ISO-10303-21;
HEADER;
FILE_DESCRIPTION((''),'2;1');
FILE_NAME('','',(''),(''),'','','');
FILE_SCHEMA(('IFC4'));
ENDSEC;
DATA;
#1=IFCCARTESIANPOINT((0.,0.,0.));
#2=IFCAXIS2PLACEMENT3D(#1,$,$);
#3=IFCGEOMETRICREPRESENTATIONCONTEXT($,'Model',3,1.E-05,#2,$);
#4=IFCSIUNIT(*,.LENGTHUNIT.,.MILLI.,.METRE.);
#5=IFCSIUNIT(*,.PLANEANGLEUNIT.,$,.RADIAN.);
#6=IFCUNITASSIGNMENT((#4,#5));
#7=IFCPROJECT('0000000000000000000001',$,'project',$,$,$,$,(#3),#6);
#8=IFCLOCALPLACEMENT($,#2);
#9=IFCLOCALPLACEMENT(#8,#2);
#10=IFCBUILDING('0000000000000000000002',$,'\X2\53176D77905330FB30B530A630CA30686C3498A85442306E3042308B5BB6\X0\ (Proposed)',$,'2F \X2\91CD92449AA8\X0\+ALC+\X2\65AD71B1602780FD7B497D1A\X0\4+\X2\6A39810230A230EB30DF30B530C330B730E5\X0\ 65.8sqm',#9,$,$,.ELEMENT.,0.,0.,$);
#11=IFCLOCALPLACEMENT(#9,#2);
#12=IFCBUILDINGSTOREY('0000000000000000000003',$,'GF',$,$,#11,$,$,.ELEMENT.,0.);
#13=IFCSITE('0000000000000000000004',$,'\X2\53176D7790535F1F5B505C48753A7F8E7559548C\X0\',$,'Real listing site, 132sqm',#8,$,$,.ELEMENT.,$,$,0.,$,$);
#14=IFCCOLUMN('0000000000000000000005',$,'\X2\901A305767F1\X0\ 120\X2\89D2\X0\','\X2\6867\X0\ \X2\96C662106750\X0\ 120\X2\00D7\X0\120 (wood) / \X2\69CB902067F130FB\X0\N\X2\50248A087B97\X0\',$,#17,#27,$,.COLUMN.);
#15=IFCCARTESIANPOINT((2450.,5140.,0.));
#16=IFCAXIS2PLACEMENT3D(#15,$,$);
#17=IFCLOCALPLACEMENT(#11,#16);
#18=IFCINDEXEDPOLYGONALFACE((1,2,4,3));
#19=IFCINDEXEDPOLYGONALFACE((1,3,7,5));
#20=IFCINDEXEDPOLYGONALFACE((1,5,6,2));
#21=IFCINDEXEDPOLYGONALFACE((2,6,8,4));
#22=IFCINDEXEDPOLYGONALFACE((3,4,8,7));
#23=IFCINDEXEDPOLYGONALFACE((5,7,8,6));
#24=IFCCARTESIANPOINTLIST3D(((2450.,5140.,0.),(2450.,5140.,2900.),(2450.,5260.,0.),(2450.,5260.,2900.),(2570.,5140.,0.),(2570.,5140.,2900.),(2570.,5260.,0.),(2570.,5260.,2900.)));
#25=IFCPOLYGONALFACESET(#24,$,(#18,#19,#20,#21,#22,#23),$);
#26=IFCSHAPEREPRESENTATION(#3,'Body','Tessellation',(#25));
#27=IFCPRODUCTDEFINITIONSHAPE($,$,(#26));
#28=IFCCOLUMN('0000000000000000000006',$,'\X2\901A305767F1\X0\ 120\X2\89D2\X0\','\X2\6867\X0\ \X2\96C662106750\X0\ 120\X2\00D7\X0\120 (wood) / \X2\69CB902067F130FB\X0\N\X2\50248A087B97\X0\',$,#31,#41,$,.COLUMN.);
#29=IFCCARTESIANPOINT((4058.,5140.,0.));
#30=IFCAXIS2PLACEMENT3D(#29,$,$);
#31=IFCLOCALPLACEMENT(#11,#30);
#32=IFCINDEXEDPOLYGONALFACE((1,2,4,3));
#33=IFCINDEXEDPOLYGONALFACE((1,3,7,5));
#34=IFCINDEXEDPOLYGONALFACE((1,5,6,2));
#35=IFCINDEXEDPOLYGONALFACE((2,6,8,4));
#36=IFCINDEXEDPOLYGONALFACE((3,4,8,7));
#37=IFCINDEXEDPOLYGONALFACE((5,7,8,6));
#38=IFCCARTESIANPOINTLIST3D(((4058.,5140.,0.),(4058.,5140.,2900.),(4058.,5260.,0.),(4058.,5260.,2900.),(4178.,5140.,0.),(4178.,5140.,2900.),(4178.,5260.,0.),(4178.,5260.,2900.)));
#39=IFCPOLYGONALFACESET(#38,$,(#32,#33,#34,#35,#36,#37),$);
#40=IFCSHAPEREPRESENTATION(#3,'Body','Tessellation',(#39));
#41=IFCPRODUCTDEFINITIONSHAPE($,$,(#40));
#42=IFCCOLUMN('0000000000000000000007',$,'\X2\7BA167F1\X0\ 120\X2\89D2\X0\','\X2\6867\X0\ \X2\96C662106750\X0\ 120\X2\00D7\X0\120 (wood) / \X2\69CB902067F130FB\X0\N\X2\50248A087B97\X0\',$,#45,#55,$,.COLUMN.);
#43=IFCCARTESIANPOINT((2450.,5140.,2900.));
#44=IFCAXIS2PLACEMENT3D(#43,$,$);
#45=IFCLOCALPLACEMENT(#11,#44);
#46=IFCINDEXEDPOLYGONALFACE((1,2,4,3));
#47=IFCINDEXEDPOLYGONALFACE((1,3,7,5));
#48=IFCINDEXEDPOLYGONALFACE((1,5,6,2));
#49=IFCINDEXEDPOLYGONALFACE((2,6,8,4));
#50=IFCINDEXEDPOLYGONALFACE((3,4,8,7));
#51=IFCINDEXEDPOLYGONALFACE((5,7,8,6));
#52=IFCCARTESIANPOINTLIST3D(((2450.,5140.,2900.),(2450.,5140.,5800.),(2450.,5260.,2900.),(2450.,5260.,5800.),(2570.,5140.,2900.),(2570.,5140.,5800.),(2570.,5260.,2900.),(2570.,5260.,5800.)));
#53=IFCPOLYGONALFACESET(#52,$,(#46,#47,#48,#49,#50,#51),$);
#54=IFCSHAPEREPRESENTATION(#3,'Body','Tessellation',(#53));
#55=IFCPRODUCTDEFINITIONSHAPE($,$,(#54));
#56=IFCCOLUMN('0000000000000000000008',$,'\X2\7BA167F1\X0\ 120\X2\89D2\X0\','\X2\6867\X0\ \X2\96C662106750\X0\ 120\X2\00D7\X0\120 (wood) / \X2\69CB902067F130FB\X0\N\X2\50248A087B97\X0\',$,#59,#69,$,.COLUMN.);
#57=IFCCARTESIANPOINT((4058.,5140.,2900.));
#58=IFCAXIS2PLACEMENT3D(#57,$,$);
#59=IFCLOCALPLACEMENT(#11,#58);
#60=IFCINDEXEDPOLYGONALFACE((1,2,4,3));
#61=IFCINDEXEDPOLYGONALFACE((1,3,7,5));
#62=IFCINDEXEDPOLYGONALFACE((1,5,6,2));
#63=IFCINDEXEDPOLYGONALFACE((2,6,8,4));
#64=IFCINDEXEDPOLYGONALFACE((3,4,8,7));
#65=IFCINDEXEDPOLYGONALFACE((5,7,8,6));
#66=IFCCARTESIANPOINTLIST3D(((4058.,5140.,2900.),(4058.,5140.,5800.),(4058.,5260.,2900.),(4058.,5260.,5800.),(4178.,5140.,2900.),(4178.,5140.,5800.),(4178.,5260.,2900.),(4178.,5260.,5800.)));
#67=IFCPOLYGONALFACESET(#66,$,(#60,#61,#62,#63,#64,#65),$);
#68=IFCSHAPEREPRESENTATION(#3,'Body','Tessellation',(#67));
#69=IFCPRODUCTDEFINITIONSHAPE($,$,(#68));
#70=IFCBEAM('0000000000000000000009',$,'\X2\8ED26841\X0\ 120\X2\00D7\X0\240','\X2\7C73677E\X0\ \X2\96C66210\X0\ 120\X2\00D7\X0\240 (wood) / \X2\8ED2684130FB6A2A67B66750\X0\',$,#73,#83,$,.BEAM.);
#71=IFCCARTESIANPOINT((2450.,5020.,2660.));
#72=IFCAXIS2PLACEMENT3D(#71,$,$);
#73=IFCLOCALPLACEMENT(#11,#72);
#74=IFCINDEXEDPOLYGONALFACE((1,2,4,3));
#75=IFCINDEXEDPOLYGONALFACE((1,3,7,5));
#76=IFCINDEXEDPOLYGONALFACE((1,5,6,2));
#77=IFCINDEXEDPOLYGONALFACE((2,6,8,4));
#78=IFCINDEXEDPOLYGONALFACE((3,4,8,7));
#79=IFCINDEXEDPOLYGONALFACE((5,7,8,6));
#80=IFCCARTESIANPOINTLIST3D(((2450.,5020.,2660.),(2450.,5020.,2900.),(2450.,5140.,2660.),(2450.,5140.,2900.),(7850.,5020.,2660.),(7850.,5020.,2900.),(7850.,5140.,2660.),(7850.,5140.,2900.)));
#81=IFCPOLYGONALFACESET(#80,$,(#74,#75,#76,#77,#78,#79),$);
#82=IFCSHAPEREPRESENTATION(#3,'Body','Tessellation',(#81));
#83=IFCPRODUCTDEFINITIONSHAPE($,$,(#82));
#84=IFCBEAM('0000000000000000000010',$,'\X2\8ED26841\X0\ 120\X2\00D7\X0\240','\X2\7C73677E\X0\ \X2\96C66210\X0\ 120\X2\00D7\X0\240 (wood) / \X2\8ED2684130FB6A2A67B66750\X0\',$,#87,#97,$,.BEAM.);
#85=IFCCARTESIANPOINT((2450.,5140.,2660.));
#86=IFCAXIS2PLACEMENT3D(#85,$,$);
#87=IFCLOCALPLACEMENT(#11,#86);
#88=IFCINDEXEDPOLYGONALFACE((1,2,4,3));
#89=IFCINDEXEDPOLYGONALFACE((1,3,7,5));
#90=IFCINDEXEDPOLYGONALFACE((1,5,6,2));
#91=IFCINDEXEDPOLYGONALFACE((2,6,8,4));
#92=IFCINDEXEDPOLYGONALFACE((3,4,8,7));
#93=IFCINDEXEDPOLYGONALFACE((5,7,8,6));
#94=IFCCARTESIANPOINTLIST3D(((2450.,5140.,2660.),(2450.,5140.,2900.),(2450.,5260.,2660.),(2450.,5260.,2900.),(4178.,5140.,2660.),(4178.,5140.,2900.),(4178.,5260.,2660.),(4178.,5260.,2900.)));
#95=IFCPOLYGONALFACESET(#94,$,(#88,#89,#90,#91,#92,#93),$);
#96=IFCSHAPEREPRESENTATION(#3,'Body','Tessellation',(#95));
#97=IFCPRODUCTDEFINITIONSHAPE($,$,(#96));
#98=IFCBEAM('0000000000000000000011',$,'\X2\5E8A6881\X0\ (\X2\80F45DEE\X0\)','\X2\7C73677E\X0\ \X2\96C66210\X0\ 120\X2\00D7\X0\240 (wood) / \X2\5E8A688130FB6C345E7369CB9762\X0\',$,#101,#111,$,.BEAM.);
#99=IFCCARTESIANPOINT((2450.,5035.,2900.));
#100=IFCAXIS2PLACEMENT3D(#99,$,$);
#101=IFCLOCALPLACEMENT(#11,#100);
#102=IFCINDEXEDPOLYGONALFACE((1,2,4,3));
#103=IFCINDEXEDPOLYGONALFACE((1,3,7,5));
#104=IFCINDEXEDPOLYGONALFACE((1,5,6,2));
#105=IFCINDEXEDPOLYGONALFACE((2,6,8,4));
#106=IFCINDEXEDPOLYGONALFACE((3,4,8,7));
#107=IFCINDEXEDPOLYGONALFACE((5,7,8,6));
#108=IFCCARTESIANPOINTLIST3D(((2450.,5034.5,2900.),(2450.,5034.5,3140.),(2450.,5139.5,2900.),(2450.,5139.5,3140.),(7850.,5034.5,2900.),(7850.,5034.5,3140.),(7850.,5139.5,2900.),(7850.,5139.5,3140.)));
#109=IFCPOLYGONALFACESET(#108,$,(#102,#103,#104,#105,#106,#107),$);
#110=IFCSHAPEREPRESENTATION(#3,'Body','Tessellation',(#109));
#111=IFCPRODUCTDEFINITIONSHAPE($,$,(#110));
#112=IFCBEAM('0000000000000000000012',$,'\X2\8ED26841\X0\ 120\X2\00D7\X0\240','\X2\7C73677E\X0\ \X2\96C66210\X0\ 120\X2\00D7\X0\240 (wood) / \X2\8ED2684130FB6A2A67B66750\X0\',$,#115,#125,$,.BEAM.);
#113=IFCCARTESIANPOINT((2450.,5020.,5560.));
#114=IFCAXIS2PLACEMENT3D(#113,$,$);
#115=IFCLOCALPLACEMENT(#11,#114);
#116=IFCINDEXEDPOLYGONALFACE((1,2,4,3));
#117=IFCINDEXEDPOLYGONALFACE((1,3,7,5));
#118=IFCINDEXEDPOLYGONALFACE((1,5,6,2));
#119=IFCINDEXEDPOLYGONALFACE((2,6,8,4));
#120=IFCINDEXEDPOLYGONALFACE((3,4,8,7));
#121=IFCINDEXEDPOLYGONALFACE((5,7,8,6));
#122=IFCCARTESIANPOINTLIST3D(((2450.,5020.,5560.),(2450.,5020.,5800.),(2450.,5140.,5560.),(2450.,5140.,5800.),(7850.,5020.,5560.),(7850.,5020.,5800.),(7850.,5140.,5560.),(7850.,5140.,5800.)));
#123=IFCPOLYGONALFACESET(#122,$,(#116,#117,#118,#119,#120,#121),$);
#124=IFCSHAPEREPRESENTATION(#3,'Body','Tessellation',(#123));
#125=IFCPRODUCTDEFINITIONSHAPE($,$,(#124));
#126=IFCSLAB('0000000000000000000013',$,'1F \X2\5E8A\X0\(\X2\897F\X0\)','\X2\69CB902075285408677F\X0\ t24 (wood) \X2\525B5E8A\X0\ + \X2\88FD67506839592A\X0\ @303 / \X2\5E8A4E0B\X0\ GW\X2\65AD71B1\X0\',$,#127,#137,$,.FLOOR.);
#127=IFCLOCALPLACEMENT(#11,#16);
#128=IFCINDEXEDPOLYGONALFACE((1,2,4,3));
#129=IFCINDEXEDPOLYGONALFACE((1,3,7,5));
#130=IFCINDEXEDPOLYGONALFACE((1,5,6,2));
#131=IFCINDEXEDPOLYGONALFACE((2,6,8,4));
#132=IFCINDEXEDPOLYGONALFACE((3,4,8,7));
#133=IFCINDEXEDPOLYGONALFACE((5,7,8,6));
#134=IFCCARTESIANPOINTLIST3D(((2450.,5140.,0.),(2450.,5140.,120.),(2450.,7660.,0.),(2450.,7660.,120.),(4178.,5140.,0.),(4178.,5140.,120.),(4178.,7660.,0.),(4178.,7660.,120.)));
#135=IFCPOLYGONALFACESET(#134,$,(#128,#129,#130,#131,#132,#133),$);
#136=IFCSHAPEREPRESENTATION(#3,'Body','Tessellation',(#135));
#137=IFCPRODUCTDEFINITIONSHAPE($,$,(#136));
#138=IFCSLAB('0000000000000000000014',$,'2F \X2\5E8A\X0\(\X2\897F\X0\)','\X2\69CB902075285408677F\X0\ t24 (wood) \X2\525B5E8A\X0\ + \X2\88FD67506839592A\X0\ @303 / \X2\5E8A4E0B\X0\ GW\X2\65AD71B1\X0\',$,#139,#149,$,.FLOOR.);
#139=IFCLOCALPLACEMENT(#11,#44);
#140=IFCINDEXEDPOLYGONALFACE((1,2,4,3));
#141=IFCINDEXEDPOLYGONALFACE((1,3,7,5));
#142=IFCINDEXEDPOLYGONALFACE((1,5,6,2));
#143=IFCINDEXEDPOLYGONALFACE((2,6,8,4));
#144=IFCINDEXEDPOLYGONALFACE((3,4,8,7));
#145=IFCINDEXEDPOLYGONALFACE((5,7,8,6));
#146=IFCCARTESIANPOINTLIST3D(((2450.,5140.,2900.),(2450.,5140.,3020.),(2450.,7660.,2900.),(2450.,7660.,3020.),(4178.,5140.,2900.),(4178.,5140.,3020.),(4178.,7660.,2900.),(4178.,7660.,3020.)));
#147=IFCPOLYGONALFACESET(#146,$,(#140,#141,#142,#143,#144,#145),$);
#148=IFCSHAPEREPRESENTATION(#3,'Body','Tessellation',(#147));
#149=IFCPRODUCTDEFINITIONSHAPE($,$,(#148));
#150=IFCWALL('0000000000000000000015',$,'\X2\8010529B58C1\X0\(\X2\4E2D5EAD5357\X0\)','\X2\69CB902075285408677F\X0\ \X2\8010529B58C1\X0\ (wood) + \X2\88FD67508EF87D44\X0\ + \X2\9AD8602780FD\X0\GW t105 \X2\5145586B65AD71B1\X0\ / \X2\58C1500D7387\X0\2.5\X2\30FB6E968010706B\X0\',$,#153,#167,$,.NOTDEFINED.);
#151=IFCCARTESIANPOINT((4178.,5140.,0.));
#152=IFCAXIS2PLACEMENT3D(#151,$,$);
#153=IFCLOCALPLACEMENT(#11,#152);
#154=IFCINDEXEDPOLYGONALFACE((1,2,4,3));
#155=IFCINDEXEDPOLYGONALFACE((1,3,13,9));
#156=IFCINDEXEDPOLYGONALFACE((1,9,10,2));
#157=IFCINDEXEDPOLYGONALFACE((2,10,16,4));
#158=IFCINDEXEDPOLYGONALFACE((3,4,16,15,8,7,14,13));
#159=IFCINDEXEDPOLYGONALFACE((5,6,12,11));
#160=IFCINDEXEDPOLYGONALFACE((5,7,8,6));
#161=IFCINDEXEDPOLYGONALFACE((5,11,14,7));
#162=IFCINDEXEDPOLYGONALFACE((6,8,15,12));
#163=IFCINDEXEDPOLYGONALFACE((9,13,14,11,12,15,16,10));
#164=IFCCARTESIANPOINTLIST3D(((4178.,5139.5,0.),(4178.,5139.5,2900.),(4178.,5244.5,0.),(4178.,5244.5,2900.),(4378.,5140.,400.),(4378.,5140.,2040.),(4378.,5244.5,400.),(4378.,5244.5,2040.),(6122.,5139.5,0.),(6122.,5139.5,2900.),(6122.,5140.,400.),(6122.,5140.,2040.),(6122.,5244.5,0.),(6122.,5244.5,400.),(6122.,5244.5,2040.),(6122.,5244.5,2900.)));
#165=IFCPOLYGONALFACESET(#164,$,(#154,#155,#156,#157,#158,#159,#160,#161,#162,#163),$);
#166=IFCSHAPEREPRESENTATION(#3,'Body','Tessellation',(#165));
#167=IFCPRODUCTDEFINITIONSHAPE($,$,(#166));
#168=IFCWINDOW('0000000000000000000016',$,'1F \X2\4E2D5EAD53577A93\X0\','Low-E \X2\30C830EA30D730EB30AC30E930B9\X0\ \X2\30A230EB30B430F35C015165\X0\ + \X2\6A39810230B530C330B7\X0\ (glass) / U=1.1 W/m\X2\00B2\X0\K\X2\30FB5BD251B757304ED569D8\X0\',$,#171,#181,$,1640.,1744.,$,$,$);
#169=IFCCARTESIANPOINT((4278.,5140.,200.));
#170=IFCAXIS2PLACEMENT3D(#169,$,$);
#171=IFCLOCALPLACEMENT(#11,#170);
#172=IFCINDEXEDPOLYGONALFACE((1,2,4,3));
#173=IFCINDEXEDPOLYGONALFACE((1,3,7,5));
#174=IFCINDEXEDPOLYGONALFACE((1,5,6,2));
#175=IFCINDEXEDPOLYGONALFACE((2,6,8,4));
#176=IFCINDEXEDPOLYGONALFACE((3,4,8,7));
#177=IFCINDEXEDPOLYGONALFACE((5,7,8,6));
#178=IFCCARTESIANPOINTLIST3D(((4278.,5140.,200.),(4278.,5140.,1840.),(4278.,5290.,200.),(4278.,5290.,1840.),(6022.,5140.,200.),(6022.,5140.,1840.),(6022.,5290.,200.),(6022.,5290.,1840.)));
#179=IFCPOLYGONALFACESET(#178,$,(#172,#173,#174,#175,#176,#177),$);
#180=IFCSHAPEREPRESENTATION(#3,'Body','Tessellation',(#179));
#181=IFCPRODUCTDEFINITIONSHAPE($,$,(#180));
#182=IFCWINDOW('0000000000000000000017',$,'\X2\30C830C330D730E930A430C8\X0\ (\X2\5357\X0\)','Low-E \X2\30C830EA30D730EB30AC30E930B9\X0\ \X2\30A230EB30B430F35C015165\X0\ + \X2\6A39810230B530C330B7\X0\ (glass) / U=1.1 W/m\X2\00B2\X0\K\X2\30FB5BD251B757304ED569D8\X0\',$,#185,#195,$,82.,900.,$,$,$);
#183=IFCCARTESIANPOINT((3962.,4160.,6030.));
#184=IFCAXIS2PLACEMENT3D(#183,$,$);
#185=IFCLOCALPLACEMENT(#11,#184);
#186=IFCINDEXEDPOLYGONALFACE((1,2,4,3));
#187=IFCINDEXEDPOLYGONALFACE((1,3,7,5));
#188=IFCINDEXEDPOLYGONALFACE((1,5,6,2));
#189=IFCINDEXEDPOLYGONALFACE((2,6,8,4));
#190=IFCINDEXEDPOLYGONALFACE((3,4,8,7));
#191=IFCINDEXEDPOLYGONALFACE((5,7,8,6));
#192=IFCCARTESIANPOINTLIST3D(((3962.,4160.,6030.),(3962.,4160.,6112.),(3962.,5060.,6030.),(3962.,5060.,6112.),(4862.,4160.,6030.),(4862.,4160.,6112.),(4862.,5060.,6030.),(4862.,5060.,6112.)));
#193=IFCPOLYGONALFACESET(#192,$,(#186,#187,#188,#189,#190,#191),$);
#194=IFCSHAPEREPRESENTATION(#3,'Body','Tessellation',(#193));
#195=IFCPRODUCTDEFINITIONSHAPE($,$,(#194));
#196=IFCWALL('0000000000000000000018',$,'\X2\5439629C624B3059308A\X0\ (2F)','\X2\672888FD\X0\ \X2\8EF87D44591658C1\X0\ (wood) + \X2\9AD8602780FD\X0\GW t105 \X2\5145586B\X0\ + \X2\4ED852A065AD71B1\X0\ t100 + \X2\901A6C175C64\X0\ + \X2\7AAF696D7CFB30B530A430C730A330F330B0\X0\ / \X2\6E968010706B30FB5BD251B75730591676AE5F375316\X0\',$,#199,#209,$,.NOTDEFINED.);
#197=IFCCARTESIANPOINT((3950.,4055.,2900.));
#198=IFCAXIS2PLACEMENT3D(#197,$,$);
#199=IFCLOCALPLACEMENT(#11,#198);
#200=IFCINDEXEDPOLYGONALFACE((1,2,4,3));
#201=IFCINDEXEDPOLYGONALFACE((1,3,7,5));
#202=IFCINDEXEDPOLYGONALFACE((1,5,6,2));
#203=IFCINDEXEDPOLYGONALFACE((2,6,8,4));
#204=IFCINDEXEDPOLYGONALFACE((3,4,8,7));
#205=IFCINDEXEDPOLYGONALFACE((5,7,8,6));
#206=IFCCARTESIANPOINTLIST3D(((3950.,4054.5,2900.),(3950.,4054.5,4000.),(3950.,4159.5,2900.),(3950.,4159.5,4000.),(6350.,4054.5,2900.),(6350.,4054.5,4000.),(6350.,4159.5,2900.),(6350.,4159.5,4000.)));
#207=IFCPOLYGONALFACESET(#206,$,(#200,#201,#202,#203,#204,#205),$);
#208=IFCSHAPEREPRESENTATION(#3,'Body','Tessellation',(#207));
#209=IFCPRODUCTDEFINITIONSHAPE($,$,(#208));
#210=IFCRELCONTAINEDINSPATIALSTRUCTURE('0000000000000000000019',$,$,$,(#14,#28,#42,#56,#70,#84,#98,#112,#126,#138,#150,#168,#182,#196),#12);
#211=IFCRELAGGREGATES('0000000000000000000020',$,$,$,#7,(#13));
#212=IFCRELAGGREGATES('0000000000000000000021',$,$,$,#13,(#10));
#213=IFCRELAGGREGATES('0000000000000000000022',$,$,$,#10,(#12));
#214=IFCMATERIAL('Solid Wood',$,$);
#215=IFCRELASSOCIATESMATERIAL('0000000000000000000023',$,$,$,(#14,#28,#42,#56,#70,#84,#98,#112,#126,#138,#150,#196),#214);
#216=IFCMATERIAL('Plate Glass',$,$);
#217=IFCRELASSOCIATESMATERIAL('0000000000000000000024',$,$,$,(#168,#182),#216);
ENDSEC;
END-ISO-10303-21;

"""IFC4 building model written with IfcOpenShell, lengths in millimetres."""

from ifc_helpers import new_model, si_unit, frame, frame_2d, origin, place, context, project, spatial, rectangle, extrude, material, element, fill, save


model = new_model("IFC4")

# Units and contexts
model_context = context("Model", 3, precision=1e-05, world=origin())
ifc_project = project(units=[si_unit("LENGTHUNIT", "METRE", prefix="MILLI"), si_unit("PLANEANGLEUNIT", "RADIAN")], contexts=[model_context])

# Site, building, storey
site_placement = place(None, origin())
site = spatial("IfcSite", under=ifc_project, at=site_placement, Name="北海道弟子屈町美留和", ObjectType="Real listing site, 132sqm", CompositionType="ELEMENT", RefElevation=0.0)
building_placement = place(site_placement, origin())
building = spatial("IfcBuilding", under=site, at=building_placement, Name="北海道・サウナと水風呂のある家 (Proposed)", ObjectType="2F 重鉄骨+ALC+断熱性能等級4+樹脂アルミサッシュ 65.8sqm", CompositionType="ELEMENT", ElevationOfRefHeight=0.0, ElevationOfTerrain=0.0)
storey_placement = place(building_placement, origin())
storey = spatial("IfcBuildingStorey", under=building, at=storey_placement, Name="GF", CompositionType="ELEMENT", Elevation=0.0)

# Columns
ifc_material_1 = material(Name="Solid Wood")
column_1_placement = place(storey_placement, frame((2450.0, 5140.0, 0.0)))
element("IfcColumn", 1, at=column_1_placement, inside=storey, material=ifc_material_1, Name="通し柱 120角", Description="桧 集成材 120×120 (wood) / 構造柱・N値計算", PredefinedType="COLUMN", context=model_context, shape_type="SweptSolid", body=[
    extrude(rectangle(XDim=120.0, YDim=120.0, at=frame_2d((60.0, 60.0))), frame((2450.0, 5140.0, 0.0)), (0.0, 0.0, 1.0), 2900.0),
])
column_2_placement = place(storey_placement, frame((4058.0, 5140.0, 0.0)))
element("IfcColumn", 2, at=column_2_placement, inside=storey, material=ifc_material_1, Name="通し柱 120角", Description="桧 集成材 120×120 (wood) / 構造柱・N値計算", PredefinedType="COLUMN", context=model_context, shape_type="SweptSolid", body=[
    extrude(rectangle(XDim=120.0, YDim=120.0, at=frame_2d((60.0, 60.0))), frame((4058.0, 5140.0, 0.0)), (0.0, 0.0, 1.0), 2900.0),
])
column_3_placement = place(storey_placement, frame((2450.0, 5140.0, 2900.0)))
element("IfcColumn", 3, at=column_3_placement, inside=storey, material=ifc_material_1, Name="管柱 120角", Description="桧 集成材 120×120 (wood) / 構造柱・N値計算", PredefinedType="COLUMN", context=model_context, shape_type="SweptSolid", body=[
    extrude(rectangle(XDim=120.0, YDim=120.0, at=frame_2d((60.0, 60.0))), frame((2450.0, 5140.0, 2900.0)), (0.0, 0.0, 1.0), 2900.0),
])
column_4_placement = place(storey_placement, frame((4058.0, 5140.0, 2900.0)))
element("IfcColumn", 4, at=column_4_placement, inside=storey, material=ifc_material_1, Name="管柱 120角", Description="桧 集成材 120×120 (wood) / 構造柱・N値計算", PredefinedType="COLUMN", context=model_context, shape_type="SweptSolid", body=[
    extrude(rectangle(XDim=120.0, YDim=120.0, at=frame_2d((60.0, 60.0))), frame((4058.0, 5140.0, 2900.0)), (0.0, 0.0, 1.0), 2900.0),
])

# Beams
beam_1_placement = place(storey_placement, frame((2450.0, 5020.0, 2660.0)))
element("IfcBeam", 5, at=beam_1_placement, inside=storey, material=ifc_material_1, Name="軒桁 120×240", Description="米松 集成 120×240 (wood) / 軒桁・横架材", PredefinedType="BEAM", context=model_context, shape_type="SweptSolid", body=[
    extrude(rectangle(XDim=5400.0, YDim=120.0, at=frame_2d((2700.0, 60.0))), frame((2450.0, 5020.0, 2660.0)), (0.0, 0.0, 1.0), 240.0),
])
beam_2_placement = place(storey_placement, frame((2450.0, 5140.0, 2660.0)))
element("IfcBeam", 6, at=beam_2_placement, inside=storey, material=ifc_material_1, Name="軒桁 120×240", Description="米松 集成 120×240 (wood) / 軒桁・横架材", PredefinedType="BEAM", context=model_context, shape_type="SweptSolid", body=[
    extrude(rectangle(XDim=1728.0, YDim=120.0, at=frame_2d((864.0, 60.0))), frame((2450.0, 5140.0, 2660.0)), (0.0, 0.0, 1.0), 240.0),
])
beam_3_placement = place(storey_placement, frame((2450.0, 5035.0, 2900.0)))
element("IfcBeam", 7, at=beam_3_placement, inside=storey, material=ifc_material_1, Name="床梁 (胴差)", Description="米松 集成 120×240 (wood) / 床梁・水平構面", PredefinedType="BEAM", context=model_context, shape_type="SweptSolid", body=[
    extrude(rectangle(XDim=5400.0, YDim=105.0, at=frame_2d((2700.0, 52.0))), frame((2450.0, 5035.0, 2900.0)), (0.0, 0.0, 1.0), 240.0),
])
beam_4_placement = place(storey_placement, frame((2450.0, 5020.0, 5560.0)))
element("IfcBeam", 8, at=beam_4_placement, inside=storey, material=ifc_material_1, Name="軒桁 120×240", Description="米松 集成 120×240 (wood) / 軒桁・横架材", PredefinedType="BEAM", context=model_context, shape_type="SweptSolid", body=[
    extrude(rectangle(XDim=5400.0, YDim=120.0, at=frame_2d((2700.0, 60.0))), frame((2450.0, 5020.0, 5560.0)), (0.0, 0.0, 1.0), 240.0),
])

# Slabs
slab_1_placement = place(storey_placement, frame((2450.0, 5140.0, 0.0)))
element("IfcSlab", 9, at=slab_1_placement, inside=storey, material=ifc_material_1, Name="1F 床(西)", Description="構造用合板 t24 (wood) 剛床 + 製材根太 @303 / 床下 GW断熱", PredefinedType="FLOOR", context=model_context, shape_type="SweptSolid", body=[
    extrude(rectangle(XDim=1728.0, YDim=2520.0, at=frame_2d((864.0, 1260.0))), frame((2450.0, 5140.0, 0.0)), (0.0, 0.0, 1.0), 120.0),
])
slab_2_placement = place(storey_placement, frame((2450.0, 5140.0, 2900.0)))
element("IfcSlab", 10, at=slab_2_placement, inside=storey, material=ifc_material_1, Name="2F 床(西)", Description="構造用合板 t24 (wood) 剛床 + 製材根太 @303 / 床下 GW断熱", PredefinedType="FLOOR", context=model_context, shape_type="SweptSolid", body=[
    extrude(rectangle(XDim=1728.0, YDim=2520.0, at=frame_2d((864.0, 1260.0))), frame((2450.0, 5140.0, 2900.0)), (0.0, 0.0, 1.0), 120.0),
])

# Wall, opening, window
wall_1_placement = place(storey_placement, frame((4178.0, 5140.0, 0.0)))
wall_1 = element("IfcWall", 11, at=wall_1_placement, inside=storey, material=ifc_material_1, Name="耐力壁(中庭南)", Description="構造用合板 耐力壁 (wood) + 製材軸組 + 高性能GW t105 充填断熱 / 壁倍率2.5・準耐火", PredefinedType="NOTDEFINED", context=model_context, shape_type="SweptSolid", body=[
    extrude(rectangle(XDim=1944.0, YDim=105.0, at=frame_2d((972.0, 52.0))), frame((4178.0, 5140.0, 0.0)), (0.0, 0.0, 1.0), 2900.0),
])
opening_placement = place(storey_placement, frame((4278.0, 5140.0, 200.0)))
opening = element("IfcOpeningElement", 12, at=opening_placement, cuts=wall_1, PredefinedType="NOTDEFINED", context=model_context, shape_type="SweptSolid", body=[
    extrude(rectangle(XDim=1744.0, YDim=150.0, at=frame_2d((872.0, 75.0))), frame((4278.0, 5140.0, 200.0)), (0.0, 0.0, 1.0), 1640.0),
])
ifc_material_2 = material(Name="Plate Glass")
window_1_placement = place(storey_placement, frame((4278.0, 5140.0, 200.0)))
window_1 = element("IfcWindow", 13, at=window_1_placement, inside=storey, material=ifc_material_2, Name="1F 中庭南窓", Description="Low-E トリプルガラス アルゴン封入 + 樹脂サッシ (glass) / U=1.1 W/m²K・寒冷地仕様", OverallHeight=1640.0, OverallWidth=1744.0, context=model_context, shape_type="SweptSolid", body=[
    extrude(rectangle(XDim=1744.0, YDim=150.0, at=frame_2d((872.0, 75.0))), frame((4278.0, 5140.0, 200.0)), (0.0, 0.0, 1.0), 1640.0),
])
fill(opening, window_1)

# Window
window_2_placement = place(storey_placement, frame((3962.0, 4160.0, 6030.0)))
element("IfcWindow", 14, at=window_2_placement, inside=storey, material=ifc_material_2, Name="トップライト (南)", Description="Low-E トリプルガラス アルゴン封入 + 樹脂サッシ (glass) / U=1.1 W/m²K・寒冷地仕様", OverallHeight=82.0, OverallWidth=900.0, context=model_context, shape_type="SweptSolid", body=[
    extrude(rectangle(XDim=900.0, YDim=900.0, at=frame_2d((450.0, 450.0))), frame((3962.0, 4160.0, 6030.0)), (0.0, 0.0, 1.0), 82.0),
])

# Wall
wall_2_placement = place(storey_placement, frame((3950.0, 4055.0, 2900.0)))
element("IfcWall", 15, at=wall_2_placement, inside=storey, material=ifc_material_1, Name="吹抜手すり (2F)", Description="木製 軸組外壁 (wood) + 高性能GW t105 充填 + 付加断熱 t100 + 通気層 + 窯業系サイディング / 準耐火・寒冷地外皮強化", PredefinedType="NOTDEFINED", context=model_context, shape_type="SweptSolid", body=[
    extrude(rectangle(XDim=2400.0, YDim=105.0, at=frame_2d((1200.0, 52.0))), frame((3950.0, 4055.0, 2900.0)), (0.0, 0.0, 1.0), 1100.0),
])

save(model, "model.ifc")
